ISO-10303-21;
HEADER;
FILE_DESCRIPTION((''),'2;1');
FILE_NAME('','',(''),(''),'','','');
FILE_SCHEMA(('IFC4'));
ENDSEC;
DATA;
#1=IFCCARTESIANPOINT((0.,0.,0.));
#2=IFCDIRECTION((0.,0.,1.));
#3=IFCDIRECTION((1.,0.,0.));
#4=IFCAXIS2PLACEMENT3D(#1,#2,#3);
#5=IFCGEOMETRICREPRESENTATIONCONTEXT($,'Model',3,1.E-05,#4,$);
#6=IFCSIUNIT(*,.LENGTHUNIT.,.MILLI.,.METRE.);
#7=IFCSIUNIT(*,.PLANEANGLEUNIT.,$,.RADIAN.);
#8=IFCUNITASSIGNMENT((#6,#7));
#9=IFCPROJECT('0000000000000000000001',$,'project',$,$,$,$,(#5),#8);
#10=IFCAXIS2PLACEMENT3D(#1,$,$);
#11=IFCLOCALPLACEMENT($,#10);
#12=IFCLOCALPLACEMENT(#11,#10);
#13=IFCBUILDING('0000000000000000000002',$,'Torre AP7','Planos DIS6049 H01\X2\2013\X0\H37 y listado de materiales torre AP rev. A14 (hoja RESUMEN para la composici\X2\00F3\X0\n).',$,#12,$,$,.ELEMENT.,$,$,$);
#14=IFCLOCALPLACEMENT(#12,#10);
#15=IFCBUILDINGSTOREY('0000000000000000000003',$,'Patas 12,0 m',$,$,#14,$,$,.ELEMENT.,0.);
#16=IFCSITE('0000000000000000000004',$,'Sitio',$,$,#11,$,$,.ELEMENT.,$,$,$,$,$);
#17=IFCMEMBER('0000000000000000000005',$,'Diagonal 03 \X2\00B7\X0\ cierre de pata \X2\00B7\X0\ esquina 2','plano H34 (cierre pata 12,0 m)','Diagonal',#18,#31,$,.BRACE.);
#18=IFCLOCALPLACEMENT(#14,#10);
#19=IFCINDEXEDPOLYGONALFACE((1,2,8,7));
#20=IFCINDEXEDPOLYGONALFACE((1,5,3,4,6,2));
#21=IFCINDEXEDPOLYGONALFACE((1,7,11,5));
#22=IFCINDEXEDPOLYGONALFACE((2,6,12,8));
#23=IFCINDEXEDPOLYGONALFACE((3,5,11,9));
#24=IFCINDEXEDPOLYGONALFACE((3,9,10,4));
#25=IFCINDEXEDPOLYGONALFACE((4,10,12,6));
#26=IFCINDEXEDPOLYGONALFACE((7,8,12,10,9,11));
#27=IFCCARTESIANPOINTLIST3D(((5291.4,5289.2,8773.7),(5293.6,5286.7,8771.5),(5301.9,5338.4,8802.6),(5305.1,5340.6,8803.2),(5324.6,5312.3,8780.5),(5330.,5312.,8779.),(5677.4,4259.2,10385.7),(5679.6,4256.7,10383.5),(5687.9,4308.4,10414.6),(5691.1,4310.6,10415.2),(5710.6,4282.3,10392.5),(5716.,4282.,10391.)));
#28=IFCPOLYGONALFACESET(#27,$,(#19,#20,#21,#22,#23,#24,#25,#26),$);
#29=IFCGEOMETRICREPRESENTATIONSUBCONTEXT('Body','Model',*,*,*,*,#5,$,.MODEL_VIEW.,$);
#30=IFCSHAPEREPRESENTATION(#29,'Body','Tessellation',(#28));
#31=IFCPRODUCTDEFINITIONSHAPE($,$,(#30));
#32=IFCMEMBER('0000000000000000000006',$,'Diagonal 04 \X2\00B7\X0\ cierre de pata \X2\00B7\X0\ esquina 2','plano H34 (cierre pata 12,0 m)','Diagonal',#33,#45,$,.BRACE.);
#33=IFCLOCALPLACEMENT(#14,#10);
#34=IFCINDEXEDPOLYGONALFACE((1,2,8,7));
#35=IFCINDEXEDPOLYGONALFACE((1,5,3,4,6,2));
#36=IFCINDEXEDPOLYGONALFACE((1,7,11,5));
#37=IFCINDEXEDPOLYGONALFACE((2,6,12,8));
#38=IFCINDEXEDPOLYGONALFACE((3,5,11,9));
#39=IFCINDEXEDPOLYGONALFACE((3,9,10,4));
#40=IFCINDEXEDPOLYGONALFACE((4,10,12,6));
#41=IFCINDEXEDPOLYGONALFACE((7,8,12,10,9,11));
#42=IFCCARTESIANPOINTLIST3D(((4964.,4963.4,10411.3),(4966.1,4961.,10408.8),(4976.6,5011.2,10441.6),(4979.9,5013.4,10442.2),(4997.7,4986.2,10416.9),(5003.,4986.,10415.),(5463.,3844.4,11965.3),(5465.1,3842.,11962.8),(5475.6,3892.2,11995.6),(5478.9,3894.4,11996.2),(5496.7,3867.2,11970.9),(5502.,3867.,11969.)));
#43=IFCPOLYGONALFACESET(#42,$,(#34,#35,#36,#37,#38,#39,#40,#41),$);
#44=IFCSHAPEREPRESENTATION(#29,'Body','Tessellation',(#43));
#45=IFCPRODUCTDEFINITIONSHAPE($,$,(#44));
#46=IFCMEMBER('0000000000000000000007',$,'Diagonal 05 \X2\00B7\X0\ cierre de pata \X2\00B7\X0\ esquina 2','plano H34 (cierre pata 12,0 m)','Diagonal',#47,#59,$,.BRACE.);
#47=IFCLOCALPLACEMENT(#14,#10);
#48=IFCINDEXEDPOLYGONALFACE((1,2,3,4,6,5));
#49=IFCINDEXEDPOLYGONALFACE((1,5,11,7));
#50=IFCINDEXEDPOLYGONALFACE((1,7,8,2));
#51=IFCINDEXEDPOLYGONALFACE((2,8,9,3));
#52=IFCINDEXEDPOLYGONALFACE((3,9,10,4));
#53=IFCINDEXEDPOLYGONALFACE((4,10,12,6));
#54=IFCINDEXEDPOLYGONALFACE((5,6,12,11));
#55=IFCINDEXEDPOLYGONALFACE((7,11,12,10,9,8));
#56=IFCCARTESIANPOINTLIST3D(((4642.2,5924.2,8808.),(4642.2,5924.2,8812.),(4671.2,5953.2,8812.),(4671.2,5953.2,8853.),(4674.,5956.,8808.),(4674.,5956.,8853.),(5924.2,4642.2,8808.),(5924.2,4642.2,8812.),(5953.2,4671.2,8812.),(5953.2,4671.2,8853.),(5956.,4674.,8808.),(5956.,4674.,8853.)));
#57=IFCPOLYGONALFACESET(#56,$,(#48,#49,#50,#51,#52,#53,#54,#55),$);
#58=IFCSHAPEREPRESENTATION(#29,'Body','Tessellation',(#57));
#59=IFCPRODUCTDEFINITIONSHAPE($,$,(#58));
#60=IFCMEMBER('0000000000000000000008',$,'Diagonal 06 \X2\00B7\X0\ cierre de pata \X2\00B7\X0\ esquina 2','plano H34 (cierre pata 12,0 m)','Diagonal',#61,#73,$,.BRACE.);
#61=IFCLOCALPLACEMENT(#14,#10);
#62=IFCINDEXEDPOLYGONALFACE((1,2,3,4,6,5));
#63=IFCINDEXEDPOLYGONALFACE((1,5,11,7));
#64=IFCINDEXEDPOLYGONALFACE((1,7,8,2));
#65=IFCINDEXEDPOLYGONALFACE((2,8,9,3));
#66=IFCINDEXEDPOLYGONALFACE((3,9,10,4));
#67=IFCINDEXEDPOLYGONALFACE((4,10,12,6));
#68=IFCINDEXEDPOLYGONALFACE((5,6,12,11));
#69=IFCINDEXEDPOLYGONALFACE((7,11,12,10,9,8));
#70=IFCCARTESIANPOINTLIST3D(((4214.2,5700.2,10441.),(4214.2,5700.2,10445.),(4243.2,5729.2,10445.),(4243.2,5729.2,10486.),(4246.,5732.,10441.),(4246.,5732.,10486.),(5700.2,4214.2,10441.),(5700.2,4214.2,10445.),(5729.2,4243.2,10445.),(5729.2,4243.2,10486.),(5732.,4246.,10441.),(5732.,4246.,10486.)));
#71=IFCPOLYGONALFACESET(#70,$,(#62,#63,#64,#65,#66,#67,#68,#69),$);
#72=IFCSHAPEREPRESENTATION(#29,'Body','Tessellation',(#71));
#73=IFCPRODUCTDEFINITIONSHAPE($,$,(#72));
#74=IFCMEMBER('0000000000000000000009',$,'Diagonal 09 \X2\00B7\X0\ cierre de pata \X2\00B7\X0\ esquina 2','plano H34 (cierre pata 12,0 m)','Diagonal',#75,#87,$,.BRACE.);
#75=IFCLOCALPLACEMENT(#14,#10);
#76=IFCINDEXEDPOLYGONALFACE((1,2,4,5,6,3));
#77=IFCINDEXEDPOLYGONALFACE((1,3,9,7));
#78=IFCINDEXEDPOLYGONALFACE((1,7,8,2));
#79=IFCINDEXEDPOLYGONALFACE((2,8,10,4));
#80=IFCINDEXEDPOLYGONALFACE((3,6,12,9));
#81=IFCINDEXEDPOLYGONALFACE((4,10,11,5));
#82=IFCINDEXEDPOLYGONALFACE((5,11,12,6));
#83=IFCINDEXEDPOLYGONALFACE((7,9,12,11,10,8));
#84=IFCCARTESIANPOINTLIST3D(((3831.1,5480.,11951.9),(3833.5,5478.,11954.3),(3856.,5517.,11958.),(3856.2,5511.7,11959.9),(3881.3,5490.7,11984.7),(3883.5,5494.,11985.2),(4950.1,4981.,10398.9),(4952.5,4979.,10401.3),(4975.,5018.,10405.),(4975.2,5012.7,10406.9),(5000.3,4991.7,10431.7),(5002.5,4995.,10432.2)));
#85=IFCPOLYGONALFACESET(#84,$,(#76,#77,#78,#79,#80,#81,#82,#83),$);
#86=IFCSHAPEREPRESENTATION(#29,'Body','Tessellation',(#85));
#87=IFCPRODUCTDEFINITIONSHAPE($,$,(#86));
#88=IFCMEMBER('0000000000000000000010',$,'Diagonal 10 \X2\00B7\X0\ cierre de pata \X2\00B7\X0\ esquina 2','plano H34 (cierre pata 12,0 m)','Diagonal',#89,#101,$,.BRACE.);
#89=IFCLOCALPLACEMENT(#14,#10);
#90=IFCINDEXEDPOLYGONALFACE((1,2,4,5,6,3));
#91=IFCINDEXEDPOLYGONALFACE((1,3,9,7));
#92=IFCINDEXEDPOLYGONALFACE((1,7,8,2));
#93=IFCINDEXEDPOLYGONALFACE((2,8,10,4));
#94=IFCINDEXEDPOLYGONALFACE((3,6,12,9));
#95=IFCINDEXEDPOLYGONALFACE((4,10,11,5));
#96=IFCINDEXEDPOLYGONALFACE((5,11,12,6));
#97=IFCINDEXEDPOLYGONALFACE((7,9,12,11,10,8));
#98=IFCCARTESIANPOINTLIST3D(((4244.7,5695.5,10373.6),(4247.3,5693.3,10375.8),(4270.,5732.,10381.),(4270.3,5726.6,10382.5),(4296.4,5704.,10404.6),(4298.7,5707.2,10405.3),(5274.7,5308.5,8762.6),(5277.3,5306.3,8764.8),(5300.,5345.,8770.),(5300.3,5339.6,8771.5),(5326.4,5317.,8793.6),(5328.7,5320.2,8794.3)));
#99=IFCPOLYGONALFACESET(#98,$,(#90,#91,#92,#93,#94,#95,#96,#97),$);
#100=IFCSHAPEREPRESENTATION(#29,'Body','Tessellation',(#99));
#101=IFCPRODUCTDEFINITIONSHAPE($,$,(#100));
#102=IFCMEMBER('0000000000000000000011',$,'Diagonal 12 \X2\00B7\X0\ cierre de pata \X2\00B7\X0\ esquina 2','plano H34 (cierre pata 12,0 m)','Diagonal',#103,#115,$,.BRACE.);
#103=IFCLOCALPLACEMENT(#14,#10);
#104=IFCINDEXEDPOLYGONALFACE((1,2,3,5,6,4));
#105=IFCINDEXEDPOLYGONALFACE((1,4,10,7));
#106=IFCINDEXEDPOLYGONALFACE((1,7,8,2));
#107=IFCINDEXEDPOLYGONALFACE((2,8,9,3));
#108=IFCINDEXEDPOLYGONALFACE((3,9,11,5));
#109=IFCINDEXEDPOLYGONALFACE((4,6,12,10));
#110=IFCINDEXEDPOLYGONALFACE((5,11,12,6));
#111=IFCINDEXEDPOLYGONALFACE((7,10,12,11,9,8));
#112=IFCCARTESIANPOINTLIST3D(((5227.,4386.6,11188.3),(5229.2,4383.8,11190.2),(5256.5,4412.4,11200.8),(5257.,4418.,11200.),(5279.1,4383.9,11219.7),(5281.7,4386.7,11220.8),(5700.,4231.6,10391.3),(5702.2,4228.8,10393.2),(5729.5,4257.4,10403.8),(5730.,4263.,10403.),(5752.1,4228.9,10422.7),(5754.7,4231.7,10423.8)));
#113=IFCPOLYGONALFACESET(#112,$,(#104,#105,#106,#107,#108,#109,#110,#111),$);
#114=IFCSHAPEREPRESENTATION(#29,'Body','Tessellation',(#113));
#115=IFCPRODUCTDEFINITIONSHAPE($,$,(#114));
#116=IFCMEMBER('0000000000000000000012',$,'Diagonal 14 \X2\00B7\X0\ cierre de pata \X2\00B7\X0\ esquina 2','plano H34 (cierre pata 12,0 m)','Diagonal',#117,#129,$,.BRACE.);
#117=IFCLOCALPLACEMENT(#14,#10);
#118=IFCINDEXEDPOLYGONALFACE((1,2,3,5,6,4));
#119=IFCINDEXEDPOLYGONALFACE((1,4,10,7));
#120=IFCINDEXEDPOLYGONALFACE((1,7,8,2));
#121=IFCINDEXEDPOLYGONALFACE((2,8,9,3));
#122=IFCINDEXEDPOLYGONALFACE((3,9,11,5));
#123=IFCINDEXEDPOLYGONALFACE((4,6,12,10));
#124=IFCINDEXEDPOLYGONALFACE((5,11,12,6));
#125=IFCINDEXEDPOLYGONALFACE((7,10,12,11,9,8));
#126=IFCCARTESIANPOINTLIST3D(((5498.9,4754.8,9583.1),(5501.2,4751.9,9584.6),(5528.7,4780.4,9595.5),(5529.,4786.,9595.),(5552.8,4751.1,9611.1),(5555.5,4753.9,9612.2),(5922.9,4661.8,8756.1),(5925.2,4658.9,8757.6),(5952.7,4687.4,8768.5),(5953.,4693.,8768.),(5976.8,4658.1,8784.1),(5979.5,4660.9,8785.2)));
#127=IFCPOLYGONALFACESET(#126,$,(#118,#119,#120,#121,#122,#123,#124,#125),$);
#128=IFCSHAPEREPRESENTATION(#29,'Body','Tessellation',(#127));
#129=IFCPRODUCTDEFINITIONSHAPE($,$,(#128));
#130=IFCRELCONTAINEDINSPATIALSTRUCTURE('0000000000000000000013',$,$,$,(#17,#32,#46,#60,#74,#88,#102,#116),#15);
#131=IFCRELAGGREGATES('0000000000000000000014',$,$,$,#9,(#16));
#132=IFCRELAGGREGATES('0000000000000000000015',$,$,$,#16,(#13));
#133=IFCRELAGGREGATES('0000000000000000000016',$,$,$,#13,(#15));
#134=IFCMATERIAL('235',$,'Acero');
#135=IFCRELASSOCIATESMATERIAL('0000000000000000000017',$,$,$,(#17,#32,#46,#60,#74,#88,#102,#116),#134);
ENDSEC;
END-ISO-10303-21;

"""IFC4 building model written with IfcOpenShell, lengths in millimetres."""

from ifc_helpers import new_model, si_unit, frame, frame_2d, origin, origin_with_axes, place, context, subcontext, project, spatial, l_section, extrude, material, element, save


model = new_model("IFC4")

# Units and contexts
model_context = context("Model", 3, precision=1e-05, world=origin_with_axes())
body_context = subcontext(model_context, "Body", "Model", "MODEL_VIEW")
ifc_project = project(units=[si_unit("LENGTHUNIT", "METRE", prefix="MILLI"), si_unit("PLANEANGLEUNIT", "RADIAN")], contexts=[model_context])

# Site, building, storey
site_placement = place(None, origin())
site = spatial("IfcSite", under=ifc_project, at=site_placement, Name="Sitio", CompositionType="ELEMENT")
building_placement = place(site_placement, origin())
building = spatial("IfcBuilding", under=site, at=building_placement, Name="Torre AP7", Description="Planos DIS6049 H01–H37 y listado de materiales torre AP rev. A14 (hoja RESUMEN para la composición).", CompositionType="ELEMENT")
storey_placement = place(building_placement, origin())
storey = spatial("IfcBuildingStorey", under=building, at=storey_placement, Name="Patas 12,0 m", CompositionType="ELEMENT", Elevation=0.0)

# Members
ifc_material_1 = material(Name="235", Category="Acero")
member_1_placement = place(storey_placement, frame((5716.0, 4282.0, 10391.0), z_axis=(-0.197794, 0.527793, -0.826022), x_axis=(-0.809734, -0.562895, -0.165772)))
element("IfcMember", 1, at=member_1_placement, inside=storey, material=ifc_material_1, Name="Diagonal 03 · cierre de pata · esquina 2", Description="plano H34 (cierre pata 12,0 m)", ObjectType="Diagonal", PredefinedType="BRACE", context=body_context, shape_type="SweptSolid", body=[
    extrude(l_section(Depth=45.0, Width=45.0, Thickness=4.0, at=frame_2d((22.5, 22.5))), None, (0.0, 0.0, 1.0), 1951.5),
])
member_2_placement = place(storey_placement, frame((5502.0, 3867.0, 11969.0), z_axis=(-0.252159, 0.565463, -0.785281), x_axis=(-0.820098, -0.55564, -0.136764)))
element("IfcMember", 2, at=member_2_placement, inside=storey, material=ifc_material_1, Name="Diagonal 04 · cierre de pata · esquina 2", Description="plano H34 (cierre pata 12,0 m)", ObjectType="Diagonal", PredefinedType="BRACE", context=body_context, shape_type="SweptSolid", body=[
    extrude(l_section(Depth=45.0, Width=45.0, Thickness=4.0, at=frame_2d((22.5, 22.5))), None, (0.0, 0.0, 1.0), 1978.9),
])
member_3_placement = place(storey_placement, frame((5956.0, 4674.0, 8808.0), z_axis=(-0.707107, 0.707107, 0.0), x_axis=(-0.707107, -0.707107, 0.0)))
element("IfcMember", 3, at=member_3_placement, inside=storey, material=ifc_material_1, Name="Diagonal 05 · cierre de pata · esquina 2", Description="plano H34 (cierre pata 12,0 m)", ObjectType="Diagonal", PredefinedType="BRACE", context=body_context, shape_type="SweptSolid", body=[
    extrude(l_section(Depth=45.0, Width=45.0, Thickness=4.0, at=frame_2d((22.5, 22.5))), None, (0.0, 0.0, 1.0), 1813.0),
])
member_4_placement = place(storey_placement, frame((5732.0, 4246.0, 10441.0), z_axis=(-0.707107, 0.707107, 0.0), x_axis=(-0.707107, -0.707107, 0.0)))
element("IfcMember", 4, at=member_4_placement, inside=storey, material=ifc_material_1, Name="Diagonal 06 · cierre de pata · esquina 2", Description="plano H34 (cierre pata 12,0 m)", ObjectType="Diagonal", PredefinedType="BRACE", context=body_context, shape_type="SweptSolid", body=[
    extrude(l_section(Depth=45.0, Width=45.0, Thickness=4.0, at=frame_2d((22.5, 22.5))), None, (0.0, 0.0, 1.0), 2101.5),
])
member_5_placement = place(storey_placement, frame((4975.0, 5018.0, 10405.0), z_axis=(-0.565688, 0.252259, 0.785088), x_axis=(-0.554271, -0.821233, -0.135501)))
element("IfcMember", 5, at=member_5_placement, inside=storey, material=ifc_material_1, Name="Diagonal 09 · cierre de pata · esquina 2", Description="plano H34 (cierre pata 12,0 m)", ObjectType="Diagonal", PredefinedType="BRACE", context=body_context, shape_type="SweptSolid", body=[
    extrude(l_section(Depth=45.0, Width=45.0, Thickness=4.0, at=frame_2d((22.5, 22.5))), None, (0.0, 0.0, 1.0), 1978.1),
])
member_6_placement = place(storey_placement, frame((5300.0, 5345.0, 8770.0), z_axis=(-0.527963, 0.198371, 0.825775), x_axis=(-0.561563, -0.810974, -0.164223)))
element("IfcMember", 6, at=member_6_placement, inside=storey, material=ifc_material_1, Name="Diagonal 10 · cierre de pata · esquina 2", Description="plano H34 (cierre pata 12,0 m)", ObjectType="Diagonal", PredefinedType="BRACE", context=body_context, shape_type="SweptSolid", body=[
    extrude(l_section(Depth=45.0, Width=45.0, Thickness=4.0, at=frame_2d((22.5, 22.5))), None, (0.0, 0.0, 1.0), 1950.9),
])
member_7_placement = place(storey_placement, frame((5730.0, 4263.0, 10403.0), z_axis=(-0.503373, 0.164953, 0.848178), x_axis=(-0.666489, -0.698843, -0.259634)))
element("IfcMember", 7, at=member_7_placement, inside=storey, material=ifc_material_1, Name="Diagonal 12 · cierre de pata · esquina 2", Description="plano H34 (cierre pata 12,0 m)", ObjectType="Diagonal", PredefinedType="BRACE", context=body_context, shape_type="SweptSolid", body=[
    extrude(l_section(Depth=45.0, Width=45.0, Thickness=4.0, at=frame_2d((22.5, 22.5))), None, (0.0, 0.0, 1.0), 939.7),
])
member_8_placement = place(storey_placement, frame((5953.0, 4693.0, 8768.0), z_axis=(-0.453962, 0.099572, 0.88544), x_axis=(-0.669105, -0.694328, -0.264967)))
element("IfcMember", 8, at=member_8_placement, inside=storey, material=ifc_material_1, Name="Diagonal 14 · cierre de pata · esquina 2", Description="plano H34 (cierre pata 12,0 m)", ObjectType="Diagonal", PredefinedType="BRACE", context=body_context, shape_type="SweptSolid", body=[
    extrude(l_section(Depth=45.0, Width=45.0, Thickness=4.0, at=frame_2d((22.5, 22.5))), None, (0.0, 0.0, 1.0), 934.0),
])

save(model, "model.ifc")
